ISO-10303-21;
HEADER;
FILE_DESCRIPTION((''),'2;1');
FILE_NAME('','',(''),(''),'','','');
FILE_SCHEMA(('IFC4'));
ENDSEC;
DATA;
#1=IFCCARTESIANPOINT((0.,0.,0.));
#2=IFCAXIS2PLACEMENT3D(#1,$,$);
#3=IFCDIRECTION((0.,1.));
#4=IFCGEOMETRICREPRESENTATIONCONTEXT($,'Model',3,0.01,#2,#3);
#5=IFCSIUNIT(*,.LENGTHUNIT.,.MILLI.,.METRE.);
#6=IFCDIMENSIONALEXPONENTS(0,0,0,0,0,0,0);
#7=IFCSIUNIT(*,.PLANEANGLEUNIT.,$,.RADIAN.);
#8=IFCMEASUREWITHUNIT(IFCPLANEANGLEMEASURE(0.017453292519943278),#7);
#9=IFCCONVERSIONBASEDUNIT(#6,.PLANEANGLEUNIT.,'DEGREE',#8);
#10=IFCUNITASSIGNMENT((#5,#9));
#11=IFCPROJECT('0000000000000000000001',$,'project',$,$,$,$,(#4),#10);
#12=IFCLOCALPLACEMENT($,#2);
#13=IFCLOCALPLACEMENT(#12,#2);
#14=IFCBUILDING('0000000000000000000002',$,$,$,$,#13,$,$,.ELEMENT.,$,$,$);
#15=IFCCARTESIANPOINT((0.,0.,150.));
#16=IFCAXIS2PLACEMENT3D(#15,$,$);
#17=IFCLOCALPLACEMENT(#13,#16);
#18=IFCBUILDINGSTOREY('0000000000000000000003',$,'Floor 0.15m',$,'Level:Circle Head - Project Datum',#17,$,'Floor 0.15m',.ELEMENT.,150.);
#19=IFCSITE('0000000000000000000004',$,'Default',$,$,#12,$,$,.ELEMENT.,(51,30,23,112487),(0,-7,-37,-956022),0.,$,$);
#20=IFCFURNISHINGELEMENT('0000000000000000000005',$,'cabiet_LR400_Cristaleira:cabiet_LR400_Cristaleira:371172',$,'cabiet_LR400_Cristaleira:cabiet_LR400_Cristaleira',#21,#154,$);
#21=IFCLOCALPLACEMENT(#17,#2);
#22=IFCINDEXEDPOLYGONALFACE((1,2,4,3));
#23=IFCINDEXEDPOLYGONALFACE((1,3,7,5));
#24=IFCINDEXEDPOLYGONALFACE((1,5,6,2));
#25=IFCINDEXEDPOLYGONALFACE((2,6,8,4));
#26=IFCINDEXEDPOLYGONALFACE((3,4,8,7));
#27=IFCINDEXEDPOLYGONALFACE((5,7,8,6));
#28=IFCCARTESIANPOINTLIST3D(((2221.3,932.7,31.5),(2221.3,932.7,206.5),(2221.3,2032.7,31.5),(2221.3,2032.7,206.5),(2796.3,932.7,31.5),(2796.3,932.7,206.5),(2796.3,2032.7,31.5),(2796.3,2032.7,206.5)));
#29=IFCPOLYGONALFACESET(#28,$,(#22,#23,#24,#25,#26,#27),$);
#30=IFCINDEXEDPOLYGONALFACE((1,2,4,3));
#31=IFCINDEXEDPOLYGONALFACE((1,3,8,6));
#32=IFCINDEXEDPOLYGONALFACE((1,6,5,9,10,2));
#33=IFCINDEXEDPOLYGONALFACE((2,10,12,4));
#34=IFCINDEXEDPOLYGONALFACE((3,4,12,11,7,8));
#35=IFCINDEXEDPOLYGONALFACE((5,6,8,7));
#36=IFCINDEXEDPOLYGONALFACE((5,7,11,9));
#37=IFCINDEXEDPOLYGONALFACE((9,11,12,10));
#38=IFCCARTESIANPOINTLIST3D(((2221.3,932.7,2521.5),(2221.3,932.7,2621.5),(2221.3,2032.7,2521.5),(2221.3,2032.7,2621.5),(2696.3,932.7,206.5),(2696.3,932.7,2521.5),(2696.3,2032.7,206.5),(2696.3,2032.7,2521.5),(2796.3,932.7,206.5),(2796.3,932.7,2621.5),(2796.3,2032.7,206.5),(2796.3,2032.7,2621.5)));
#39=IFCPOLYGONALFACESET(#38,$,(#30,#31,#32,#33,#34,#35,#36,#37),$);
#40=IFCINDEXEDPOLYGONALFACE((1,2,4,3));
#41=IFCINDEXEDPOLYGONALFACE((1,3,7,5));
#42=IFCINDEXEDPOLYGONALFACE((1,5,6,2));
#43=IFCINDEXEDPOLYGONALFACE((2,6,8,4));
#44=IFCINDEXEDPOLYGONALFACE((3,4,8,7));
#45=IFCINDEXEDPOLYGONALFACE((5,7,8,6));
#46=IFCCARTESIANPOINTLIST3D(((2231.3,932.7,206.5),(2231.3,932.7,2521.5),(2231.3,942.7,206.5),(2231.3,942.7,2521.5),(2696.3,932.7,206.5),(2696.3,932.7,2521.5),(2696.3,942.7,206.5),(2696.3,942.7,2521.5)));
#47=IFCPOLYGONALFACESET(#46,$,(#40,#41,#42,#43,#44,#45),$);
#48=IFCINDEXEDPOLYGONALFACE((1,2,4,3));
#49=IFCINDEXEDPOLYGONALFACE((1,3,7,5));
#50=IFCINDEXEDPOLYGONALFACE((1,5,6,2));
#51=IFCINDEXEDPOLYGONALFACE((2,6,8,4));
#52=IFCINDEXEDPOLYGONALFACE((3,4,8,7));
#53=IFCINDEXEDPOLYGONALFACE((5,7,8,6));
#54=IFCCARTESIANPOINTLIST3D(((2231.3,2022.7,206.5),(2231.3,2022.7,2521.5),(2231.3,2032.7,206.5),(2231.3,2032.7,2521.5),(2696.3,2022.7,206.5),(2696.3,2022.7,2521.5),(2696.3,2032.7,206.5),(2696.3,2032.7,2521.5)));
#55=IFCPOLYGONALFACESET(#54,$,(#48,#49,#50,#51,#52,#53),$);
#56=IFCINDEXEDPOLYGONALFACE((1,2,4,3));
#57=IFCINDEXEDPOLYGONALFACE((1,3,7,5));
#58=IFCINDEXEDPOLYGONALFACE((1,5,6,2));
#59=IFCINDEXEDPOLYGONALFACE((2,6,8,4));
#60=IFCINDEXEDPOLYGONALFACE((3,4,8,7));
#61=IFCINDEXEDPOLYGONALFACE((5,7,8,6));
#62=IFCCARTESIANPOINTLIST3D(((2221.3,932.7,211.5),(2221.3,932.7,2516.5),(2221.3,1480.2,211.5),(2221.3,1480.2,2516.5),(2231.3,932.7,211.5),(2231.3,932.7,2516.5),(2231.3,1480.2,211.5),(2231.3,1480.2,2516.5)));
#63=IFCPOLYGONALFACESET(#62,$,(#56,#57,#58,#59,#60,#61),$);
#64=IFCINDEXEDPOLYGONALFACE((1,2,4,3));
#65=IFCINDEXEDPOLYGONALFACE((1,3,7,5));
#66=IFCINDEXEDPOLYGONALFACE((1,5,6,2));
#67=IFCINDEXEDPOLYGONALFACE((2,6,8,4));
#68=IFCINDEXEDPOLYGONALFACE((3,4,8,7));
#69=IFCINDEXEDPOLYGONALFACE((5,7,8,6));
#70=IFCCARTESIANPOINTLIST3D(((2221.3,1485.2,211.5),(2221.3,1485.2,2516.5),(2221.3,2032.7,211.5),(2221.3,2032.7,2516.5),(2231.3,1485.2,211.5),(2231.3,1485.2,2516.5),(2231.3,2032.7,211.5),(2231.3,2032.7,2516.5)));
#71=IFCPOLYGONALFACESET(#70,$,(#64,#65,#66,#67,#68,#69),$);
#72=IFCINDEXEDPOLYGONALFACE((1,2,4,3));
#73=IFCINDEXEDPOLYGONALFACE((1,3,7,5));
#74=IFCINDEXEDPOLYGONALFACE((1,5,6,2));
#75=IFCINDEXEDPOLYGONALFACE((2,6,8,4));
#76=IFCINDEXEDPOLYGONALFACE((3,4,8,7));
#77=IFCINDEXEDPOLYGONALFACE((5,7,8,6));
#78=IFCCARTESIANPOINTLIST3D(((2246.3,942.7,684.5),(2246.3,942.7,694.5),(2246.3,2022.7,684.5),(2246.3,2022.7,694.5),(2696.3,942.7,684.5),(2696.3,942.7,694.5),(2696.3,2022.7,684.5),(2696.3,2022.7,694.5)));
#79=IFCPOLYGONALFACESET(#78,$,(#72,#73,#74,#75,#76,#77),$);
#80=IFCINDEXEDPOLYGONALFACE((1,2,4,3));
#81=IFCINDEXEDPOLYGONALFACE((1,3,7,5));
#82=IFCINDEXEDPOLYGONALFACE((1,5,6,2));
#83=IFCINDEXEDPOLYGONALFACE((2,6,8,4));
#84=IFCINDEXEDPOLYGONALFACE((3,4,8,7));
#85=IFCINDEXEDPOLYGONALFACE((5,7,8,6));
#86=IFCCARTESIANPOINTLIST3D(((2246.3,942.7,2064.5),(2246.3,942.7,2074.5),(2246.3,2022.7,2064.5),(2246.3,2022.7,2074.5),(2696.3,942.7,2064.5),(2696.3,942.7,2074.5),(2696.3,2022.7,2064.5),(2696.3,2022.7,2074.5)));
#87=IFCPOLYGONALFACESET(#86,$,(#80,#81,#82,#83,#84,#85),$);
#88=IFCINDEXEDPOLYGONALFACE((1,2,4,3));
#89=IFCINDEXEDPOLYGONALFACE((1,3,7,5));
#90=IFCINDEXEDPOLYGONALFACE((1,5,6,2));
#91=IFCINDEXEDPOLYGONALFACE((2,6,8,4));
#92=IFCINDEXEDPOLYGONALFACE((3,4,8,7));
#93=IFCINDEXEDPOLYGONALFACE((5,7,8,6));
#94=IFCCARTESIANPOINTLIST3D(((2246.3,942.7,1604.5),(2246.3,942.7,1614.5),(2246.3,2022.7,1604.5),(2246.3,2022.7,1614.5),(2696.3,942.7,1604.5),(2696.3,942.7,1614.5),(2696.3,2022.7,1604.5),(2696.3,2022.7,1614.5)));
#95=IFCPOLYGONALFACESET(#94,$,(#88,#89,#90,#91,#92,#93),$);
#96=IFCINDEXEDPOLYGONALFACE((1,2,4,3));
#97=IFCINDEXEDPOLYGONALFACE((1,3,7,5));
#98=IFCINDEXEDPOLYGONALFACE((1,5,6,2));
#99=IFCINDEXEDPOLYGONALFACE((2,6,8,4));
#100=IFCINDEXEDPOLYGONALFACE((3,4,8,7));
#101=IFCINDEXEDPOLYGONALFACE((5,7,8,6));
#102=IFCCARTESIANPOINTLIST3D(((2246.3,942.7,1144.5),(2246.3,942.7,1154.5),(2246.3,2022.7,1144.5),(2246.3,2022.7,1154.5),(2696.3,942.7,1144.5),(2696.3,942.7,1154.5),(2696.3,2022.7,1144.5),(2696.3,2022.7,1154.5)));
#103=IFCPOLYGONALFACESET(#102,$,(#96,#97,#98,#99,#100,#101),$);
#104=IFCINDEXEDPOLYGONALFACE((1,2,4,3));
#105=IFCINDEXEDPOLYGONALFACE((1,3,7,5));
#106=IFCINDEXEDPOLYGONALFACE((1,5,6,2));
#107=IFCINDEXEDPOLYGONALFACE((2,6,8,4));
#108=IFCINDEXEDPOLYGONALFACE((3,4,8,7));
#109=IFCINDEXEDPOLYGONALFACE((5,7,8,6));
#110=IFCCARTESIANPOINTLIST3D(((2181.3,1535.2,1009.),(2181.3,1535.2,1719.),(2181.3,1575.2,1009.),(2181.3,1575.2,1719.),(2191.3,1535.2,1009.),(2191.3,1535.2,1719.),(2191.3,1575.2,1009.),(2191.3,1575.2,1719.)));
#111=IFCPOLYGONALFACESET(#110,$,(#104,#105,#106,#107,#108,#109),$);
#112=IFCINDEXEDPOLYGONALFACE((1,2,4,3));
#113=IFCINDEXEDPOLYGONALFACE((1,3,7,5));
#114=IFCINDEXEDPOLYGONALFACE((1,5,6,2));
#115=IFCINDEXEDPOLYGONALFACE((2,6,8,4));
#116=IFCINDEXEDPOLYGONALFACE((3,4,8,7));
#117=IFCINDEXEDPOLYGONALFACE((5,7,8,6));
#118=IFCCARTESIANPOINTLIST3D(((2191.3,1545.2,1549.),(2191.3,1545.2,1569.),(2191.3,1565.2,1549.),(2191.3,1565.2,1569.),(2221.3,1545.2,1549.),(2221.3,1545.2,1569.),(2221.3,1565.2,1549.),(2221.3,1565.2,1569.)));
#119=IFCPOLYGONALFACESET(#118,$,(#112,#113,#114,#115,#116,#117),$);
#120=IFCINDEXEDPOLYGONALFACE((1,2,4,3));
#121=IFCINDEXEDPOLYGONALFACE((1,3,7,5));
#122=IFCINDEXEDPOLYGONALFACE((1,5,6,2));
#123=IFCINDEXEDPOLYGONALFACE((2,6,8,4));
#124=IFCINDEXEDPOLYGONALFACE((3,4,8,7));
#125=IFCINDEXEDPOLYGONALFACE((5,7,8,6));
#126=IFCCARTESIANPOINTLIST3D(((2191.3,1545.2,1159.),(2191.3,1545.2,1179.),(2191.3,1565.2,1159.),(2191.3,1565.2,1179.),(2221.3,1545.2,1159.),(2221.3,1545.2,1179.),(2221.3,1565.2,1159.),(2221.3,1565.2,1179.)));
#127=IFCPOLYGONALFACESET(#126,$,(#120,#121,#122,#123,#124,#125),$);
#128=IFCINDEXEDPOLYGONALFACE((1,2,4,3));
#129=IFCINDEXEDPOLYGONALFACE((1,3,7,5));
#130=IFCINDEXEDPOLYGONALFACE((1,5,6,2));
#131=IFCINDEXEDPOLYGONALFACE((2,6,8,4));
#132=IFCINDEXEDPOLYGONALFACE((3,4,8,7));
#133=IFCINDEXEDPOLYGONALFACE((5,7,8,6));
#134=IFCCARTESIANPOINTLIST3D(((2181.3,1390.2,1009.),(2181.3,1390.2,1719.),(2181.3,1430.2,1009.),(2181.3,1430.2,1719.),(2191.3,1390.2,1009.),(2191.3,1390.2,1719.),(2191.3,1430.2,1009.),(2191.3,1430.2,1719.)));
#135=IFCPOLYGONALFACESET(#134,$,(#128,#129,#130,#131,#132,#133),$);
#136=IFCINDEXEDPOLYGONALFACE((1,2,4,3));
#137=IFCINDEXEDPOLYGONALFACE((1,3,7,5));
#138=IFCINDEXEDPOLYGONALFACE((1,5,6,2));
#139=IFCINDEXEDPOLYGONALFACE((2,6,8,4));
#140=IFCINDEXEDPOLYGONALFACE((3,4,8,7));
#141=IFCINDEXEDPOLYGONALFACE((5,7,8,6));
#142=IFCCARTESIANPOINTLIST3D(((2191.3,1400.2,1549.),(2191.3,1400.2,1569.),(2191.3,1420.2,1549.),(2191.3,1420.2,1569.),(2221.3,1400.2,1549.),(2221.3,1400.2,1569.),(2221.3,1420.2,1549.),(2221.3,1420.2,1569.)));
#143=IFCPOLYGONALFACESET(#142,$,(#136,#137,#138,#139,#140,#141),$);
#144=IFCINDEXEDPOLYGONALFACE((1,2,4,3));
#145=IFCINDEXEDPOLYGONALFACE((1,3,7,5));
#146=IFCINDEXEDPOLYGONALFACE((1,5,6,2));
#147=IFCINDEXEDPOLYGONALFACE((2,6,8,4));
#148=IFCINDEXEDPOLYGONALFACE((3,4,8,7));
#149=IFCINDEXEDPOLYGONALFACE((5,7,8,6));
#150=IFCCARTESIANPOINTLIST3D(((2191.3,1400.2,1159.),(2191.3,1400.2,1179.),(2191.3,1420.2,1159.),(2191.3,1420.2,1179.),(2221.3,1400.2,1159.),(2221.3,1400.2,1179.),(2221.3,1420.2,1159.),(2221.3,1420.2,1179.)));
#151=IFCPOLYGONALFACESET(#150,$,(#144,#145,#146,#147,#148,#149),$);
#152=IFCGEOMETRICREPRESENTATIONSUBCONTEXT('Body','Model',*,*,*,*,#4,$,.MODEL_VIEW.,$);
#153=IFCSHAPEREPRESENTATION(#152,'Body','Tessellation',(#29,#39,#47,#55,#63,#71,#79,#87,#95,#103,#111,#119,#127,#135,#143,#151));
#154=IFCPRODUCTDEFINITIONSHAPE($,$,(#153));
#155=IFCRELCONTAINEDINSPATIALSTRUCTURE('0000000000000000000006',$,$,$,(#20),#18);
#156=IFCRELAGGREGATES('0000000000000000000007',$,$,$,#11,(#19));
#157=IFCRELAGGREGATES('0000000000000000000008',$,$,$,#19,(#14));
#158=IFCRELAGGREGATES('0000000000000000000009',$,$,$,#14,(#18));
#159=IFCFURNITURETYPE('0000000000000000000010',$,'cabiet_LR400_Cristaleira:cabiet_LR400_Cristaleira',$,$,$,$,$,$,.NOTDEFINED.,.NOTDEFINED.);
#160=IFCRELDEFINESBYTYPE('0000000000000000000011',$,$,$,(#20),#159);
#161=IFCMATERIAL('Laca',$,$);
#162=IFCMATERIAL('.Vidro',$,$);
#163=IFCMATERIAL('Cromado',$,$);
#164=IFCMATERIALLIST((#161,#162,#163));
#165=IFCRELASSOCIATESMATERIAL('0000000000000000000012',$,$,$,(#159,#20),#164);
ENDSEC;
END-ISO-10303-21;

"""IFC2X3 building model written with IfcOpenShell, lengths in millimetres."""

from ifc_helpers import new_model, entity, si_unit, converted_unit, direction, frame, frame_2d, origin, origin_2d_with_axis, place, context, subcontext, project, spatial, polyline, rectangle, outline, extrude, source, transform, mapped, material, material_list, type_object, type_shapes, element, save


model = new_model("IFC2X3")

# Units and contexts
model_context = context("Model", 3, precision=0.01, world=origin(), true_north=direction((0.0, 1.0)))
body_context = subcontext(model_context, "Body", "Model", "MODEL_VIEW")
ifc_project = project(units=[si_unit("LENGTHUNIT", "METRE", prefix="MILLI"), converted_unit("PLANEANGLEUNIT", "DEGREE", entity("IfcPlaneAngleMeasure", 0.017453292519943278), si_unit("PLANEANGLEUNIT", "RADIAN"), dimensions=[0, 0, 0, 0, 0, 0, 0])], contexts=[model_context])

# Site, building, storey
site_placement = place(None, origin())
site = spatial("IfcSite", under=ifc_project, at=site_placement, Name="Default", CompositionType="ELEMENT", RefLatitude=(51, 30, 23, 112487), RefLongitude=(0, -7, -37, -956022), RefElevation=0.0)
building_placement = place(site_placement, origin())
building = spatial("IfcBuilding", under=site, at=building_placement, CompositionType="ELEMENT")
storey_placement = place(building_placement, frame((0.0, 0.0, 150.0)))
storey = spatial("IfcBuildingStorey", under=building, at=storey_placement, Name="Floor 0.15m", ObjectType="Level:Circle Head - Project Datum", LongName="Floor 0.15m", CompositionType="ELEMENT", Elevation=150.0)

# Furnishing element
ifc_material_1 = material(Name="Laca")
ifc_material_2 = material(Name=".Vidro")
ifc_material_3 = material(Name="Cromado")
ifc_material_list = material_list([ifc_material_1, ifc_material_2, ifc_material_3])
furniture_type_1 = type_object("IfcFurnitureType", Name="cabiet_LR400_Cristaleira:cabiet_LR400_Cristaleira", AssemblyPlace="NOTDEFINED", material=ifc_material_list)
shared_shape_1 = source(origin(), body_context, "Body", "SweptSolid", [
    extrude(rectangle(XDim=575.0, YDim=1100.0, at=origin_2d_with_axis()), frame((287.5, 550.0, 31.5), z_axis=(0.0, 0.0, 1.0), x_axis=(-1.0, 0.0, 0.0)), (0.0, 0.0, 1.0), 175.0),
    extrude(outline(polyline([(-225.0, -838.3), (350.0, -838.3), (350.0, -738.3), (-125.0, -738.3), (-125.0, 1576.7), (-225.0, 1576.7), (-225.0, -838.3)])), frame((225.0, 0.0, 1783.2), z_axis=(0.0, 1.0, 0.0), x_axis=(1.0, 0.0, 0.0)), (0.0, 0.0, 1.0), 1100.0),
    extrude(rectangle(XDim=465.0, YDim=10.0, at=origin_2d_with_axis()), frame((332.5, 1095.0, 206.5), z_axis=(0.0, 0.0, 1.0), x_axis=(-1.0, 0.0, 0.0)), (0.0, 0.0, 1.0), 2315.0),
    extrude(rectangle(XDim=10.0, YDim=465.0, at=origin_2d_with_axis()), frame((332.5, 5.0, 206.5), z_axis=(0.0, 0.0, 1.0), x_axis=(0.0, 1.0, 0.0)), (0.0, 0.0, 1.0), 2315.0),
    extrude(rectangle(XDim=547.5, YDim=10.0, at=origin_2d_with_axis()), frame((570.0, 826.3, 211.5), z_axis=(0.0, 0.0, 1.0), x_axis=(0.0, 1.0, 0.0)), (0.0, 0.0, 1.0), 2305.0),
    extrude(rectangle(XDim=547.5, YDim=10.0, at=origin_2d_with_axis()), frame((570.0, 273.8, 211.5), z_axis=(0.0, 0.0, 1.0), x_axis=(0.0, 1.0, 0.0)), (0.0, 0.0, 1.0), 2305.0),
    extrude(rectangle(XDim=450.0, YDim=1080.0, at=frame_2d((0.0, 0.0), x_axis=(1.0, 0.0))), frame((325.0, 550.0, 684.5), z_axis=(0.0, 0.0, 1.0), x_axis=(-1.0, 0.0, 0.0)), (0.0, 0.0, 1.0), 10.0),
    extrude(rectangle(XDim=450.0, YDim=1080.0, at=frame_2d((0.0, 0.0), x_axis=(1.0, 0.0))), frame((325.0, 550.0, 2064.5), z_axis=(0.0, 0.0, 1.0), x_axis=(-1.0, 0.0, 0.0)), (0.0, 0.0, 1.0), 10.0),
    extrude(rectangle(XDim=450.0, YDim=1080.0, at=frame_2d((0.0, 0.0), x_axis=(1.0, 0.0))), frame((325.0, 550.0, 1604.5), z_axis=(0.0, 0.0, 1.0), x_axis=(-1.0, 0.0, 0.0)), (0.0, 0.0, 1.0), 10.0),
    extrude(rectangle(XDim=450.0, YDim=1080.0, at=frame_2d((0.0, 0.0), x_axis=(1.0, 0.0))), frame((325.0, 550.0, 1144.5), z_axis=(0.0, 0.0, 1.0), x_axis=(-1.0, 0.0, 0.0)), (0.0, 0.0, 1.0), 10.0),
    extrude(rectangle(XDim=10.0, YDim=40.0, at=frame_2d((0.0, 0.0), x_axis=(1.0, 0.0))), frame((610.0, 477.5, 1009.0), z_axis=(0.0, 0.0, 1.0), x_axis=(-1.0, 0.0, 0.0)), (0.0, 0.0, 1.0), 710.0),
    extrude(rectangle(XDim=30.0, YDim=20.0, at=frame_2d((0.0, 0.0), x_axis=(1.0, 0.0))), frame((590.0, 477.5, 1549.0), z_axis=(0.0, 0.0, 1.0), x_axis=(-1.0, 0.0, 0.0)), (0.0, 0.0, 1.0), 20.0),
    extrude(rectangle(XDim=30.0, YDim=20.0, at=frame_2d((0.0, 0.0), x_axis=(1.0, 0.0))), frame((590.0, 477.5, 1159.0), z_axis=(0.0, 0.0, 1.0), x_axis=(-1.0, 0.0, 0.0)), (0.0, 0.0, 1.0), 20.0),
    extrude(rectangle(XDim=10.0, YDim=40.0, at=frame_2d((0.0, 0.0), x_axis=(1.0, 0.0))), frame((610.0, 622.5, 1009.0), z_axis=(0.0, 0.0, 1.0), x_axis=(-1.0, 0.0, 0.0)), (0.0, 0.0, 1.0), 710.0),
    extrude(rectangle(XDim=30.0, YDim=20.0, at=frame_2d((0.0, 0.0), x_axis=(1.0, 0.0))), frame((590.0, 622.5, 1549.0), z_axis=(0.0, 0.0, 1.0), x_axis=(-1.0, 0.0, 0.0)), (0.0, 0.0, 1.0), 20.0),
    extrude(rectangle(XDim=30.0, YDim=20.0, at=frame_2d((0.0, 0.0), x_axis=(1.0, 0.0))), frame((590.0, 622.5, 1159.0), z_axis=(0.0, 0.0, 1.0), x_axis=(-1.0, 0.0, 0.0)), (0.0, 0.0, 1.0), 20.0),
])
type_shapes(furniture_type_1, [shared_shape_1])
furnishing_1_placement = place(storey_placement, frame((2796.3, 2032.7, 0.0), z_axis=(0.0, 0.0, 1.0), x_axis=(-1.0, 0.0, 0.0)))
element("IfcFurnishingElement", 1, at=furnishing_1_placement, inside=storey, type_object=furniture_type_1, material=ifc_material_list, Name="cabiet_LR400_Cristaleira:cabiet_LR400_Cristaleira:371172", ObjectType="cabiet_LR400_Cristaleira:cabiet_LR400_Cristaleira", context=body_context, shape_type="MappedRepresentation", body=[
    mapped(shared_shape_1, transform((0.0, 0.0, 0.0), scale=1.0)),
])

save(model, "model.ifc")
